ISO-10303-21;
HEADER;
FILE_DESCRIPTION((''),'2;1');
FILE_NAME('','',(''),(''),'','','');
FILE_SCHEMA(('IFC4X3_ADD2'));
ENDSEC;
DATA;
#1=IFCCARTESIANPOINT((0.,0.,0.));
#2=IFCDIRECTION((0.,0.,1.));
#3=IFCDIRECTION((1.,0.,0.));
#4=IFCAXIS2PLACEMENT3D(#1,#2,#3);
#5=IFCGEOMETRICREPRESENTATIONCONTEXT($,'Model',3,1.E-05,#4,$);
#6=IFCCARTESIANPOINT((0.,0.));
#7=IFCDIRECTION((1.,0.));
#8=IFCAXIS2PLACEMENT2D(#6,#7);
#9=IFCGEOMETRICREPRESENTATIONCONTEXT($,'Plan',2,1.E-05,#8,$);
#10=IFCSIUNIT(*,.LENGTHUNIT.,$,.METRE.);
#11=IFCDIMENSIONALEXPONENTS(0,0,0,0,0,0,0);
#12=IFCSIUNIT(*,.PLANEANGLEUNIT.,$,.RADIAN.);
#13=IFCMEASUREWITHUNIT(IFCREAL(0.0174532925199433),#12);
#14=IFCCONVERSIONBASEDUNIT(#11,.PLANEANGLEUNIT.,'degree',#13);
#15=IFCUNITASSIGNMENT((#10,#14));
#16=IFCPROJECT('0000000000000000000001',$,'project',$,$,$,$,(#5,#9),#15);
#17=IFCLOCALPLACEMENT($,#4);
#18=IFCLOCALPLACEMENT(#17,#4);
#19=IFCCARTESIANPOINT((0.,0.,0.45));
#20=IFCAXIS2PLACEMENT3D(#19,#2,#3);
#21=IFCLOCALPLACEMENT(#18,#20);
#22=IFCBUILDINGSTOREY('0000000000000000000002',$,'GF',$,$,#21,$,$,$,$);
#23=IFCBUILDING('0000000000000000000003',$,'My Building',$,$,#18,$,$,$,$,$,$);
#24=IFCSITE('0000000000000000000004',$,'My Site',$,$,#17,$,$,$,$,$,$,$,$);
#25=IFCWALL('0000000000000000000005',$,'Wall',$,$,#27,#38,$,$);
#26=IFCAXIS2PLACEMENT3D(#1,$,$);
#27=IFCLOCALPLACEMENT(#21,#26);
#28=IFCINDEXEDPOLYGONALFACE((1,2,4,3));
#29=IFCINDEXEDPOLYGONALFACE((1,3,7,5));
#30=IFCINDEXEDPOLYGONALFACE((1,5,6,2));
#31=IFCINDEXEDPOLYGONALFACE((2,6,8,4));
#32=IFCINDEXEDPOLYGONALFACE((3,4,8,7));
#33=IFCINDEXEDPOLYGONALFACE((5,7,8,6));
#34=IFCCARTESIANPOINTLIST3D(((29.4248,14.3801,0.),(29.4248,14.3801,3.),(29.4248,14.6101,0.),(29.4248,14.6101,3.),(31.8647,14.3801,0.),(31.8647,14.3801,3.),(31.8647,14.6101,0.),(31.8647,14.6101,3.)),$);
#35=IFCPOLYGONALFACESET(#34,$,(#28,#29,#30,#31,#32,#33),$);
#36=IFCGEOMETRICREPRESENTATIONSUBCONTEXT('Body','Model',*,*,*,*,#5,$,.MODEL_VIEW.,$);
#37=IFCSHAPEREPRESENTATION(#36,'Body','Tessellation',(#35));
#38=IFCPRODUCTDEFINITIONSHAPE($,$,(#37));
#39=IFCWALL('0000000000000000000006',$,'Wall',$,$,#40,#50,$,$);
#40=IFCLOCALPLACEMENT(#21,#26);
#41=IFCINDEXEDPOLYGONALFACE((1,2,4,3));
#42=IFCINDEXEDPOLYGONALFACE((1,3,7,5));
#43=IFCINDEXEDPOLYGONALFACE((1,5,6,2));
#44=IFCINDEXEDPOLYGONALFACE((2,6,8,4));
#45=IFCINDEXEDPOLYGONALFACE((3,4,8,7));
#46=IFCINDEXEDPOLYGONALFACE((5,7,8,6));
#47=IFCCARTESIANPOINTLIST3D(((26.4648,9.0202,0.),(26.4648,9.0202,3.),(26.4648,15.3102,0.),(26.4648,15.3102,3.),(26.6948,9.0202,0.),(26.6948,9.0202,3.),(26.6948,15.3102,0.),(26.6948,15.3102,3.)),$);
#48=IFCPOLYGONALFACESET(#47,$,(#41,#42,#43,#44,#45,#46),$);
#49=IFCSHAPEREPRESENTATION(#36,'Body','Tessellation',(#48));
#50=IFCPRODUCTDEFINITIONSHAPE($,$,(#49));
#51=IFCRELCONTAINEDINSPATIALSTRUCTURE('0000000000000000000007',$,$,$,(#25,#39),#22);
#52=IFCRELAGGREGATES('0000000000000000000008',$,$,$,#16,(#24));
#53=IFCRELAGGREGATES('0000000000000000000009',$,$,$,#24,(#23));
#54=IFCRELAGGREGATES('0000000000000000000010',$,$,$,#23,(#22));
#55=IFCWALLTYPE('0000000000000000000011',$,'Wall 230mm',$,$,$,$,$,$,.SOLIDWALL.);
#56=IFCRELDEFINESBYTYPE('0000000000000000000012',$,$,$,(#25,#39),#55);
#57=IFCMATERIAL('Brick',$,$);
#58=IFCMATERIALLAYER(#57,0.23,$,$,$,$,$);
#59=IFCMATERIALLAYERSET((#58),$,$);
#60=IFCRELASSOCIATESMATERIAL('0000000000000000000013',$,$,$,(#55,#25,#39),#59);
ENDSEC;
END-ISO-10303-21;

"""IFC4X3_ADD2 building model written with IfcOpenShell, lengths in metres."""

from ifc_helpers import new_model, entity, si_unit, converted_unit, frame, origin_with_axes, origin_2d_with_axis, place, context, subcontext, project, spatial, indexed_curve, outline, extrude, material, layer, layer_set, layer_usage, type_object, element, save


model = new_model("IFC4X3_ADD2")

# Units and contexts
model_context = context("Model", 3, precision=1e-05, world=origin_with_axes())
plan_context = context("Plan", 2, precision=1e-05, world=origin_2d_with_axis())
body_context = subcontext(model_context, "Body", "Model", "MODEL_VIEW")
ifc_project = project(units=[si_unit("LENGTHUNIT", "METRE"), converted_unit("PLANEANGLEUNIT", "degree", entity("IfcReal", 0.0174532925199433), si_unit("PLANEANGLEUNIT", "RADIAN"), dimensions=[0, 0, 0, 0, 0, 0, 0])], contexts=[model_context, plan_context])

# Site, building, storey
site_placement = place(None, origin_with_axes())
site = spatial("IfcSite", under=ifc_project, at=site_placement, Name="My Site")
building_placement = place(site_placement, origin_with_axes())
building = spatial("IfcBuilding", under=site, at=building_placement, Name="My Building")
storey_placement = place(building_placement, frame((0.0, 0.0, 0.45), z_axis=(0.0, 0.0, 1.0), x_axis=(1.0, 0.0, 0.0)))
storey = spatial("IfcBuildingStorey", under=building, at=storey_placement, Name="GF")

# Walls
ifc_material_1 = material(Name="Brick")
ifc_layer_1 = layer(ifc_material_1, 0.23)
ifc_layer_set_1 = layer_set([ifc_layer_1])
wall_type_1 = type_object("IfcWallType", Name="Wall 230mm", PredefinedType="SOLIDWALL", material=ifc_layer_set_1)
ifc_layer_usage_1 = layer_usage(ifc_layer_set_1, "AXIS2", "POSITIVE", 0.0)
wall_1_placement = place(storey_placement, frame((31.8647, 14.6101, 0.0), z_axis=(0.0, 0.0, 1.0), x_axis=(-1.0, 0.0, 0.0)))
element("IfcWall", 1, at=wall_1_placement, inside=storey, type_object=wall_type_1, material=ifc_layer_usage_1, Name="Wall", context=body_context, shape_type="SweptSolid", body=[
    extrude(outline(indexed_curve([(0.0, 0.0), (0.0, 0.23), (2.44, 0.23), (2.44, 0.0), (0.0, 0.0)], self_intersect=False)), origin_with_axes(), (0.0, 0.0, 1.0), 3.0),
])
ifc_layer_usage_2 = layer_usage(ifc_layer_set_1, "AXIS2", "POSITIVE", 0.0)
wall_2_placement = place(storey_placement, frame((26.6948, 9.0202, 0.0), z_axis=(0.0, 0.0, 1.0), x_axis=(0.000001, 1.0, 0.0)))
element("IfcWall", 2, at=wall_2_placement, inside=storey, type_object=wall_type_1, material=ifc_layer_usage_2, Name="Wall", context=body_context, shape_type="SweptSolid", body=[
    extrude(outline(indexed_curve([(0.0, 0.0), (0.0, 0.23), (6.29, 0.23), (6.29, 0.0), (0.0, 0.0)], self_intersect=False)), origin_with_axes(), (0.0, 0.0, 1.0), 3.0),
])

save(model, "model.ifc")
